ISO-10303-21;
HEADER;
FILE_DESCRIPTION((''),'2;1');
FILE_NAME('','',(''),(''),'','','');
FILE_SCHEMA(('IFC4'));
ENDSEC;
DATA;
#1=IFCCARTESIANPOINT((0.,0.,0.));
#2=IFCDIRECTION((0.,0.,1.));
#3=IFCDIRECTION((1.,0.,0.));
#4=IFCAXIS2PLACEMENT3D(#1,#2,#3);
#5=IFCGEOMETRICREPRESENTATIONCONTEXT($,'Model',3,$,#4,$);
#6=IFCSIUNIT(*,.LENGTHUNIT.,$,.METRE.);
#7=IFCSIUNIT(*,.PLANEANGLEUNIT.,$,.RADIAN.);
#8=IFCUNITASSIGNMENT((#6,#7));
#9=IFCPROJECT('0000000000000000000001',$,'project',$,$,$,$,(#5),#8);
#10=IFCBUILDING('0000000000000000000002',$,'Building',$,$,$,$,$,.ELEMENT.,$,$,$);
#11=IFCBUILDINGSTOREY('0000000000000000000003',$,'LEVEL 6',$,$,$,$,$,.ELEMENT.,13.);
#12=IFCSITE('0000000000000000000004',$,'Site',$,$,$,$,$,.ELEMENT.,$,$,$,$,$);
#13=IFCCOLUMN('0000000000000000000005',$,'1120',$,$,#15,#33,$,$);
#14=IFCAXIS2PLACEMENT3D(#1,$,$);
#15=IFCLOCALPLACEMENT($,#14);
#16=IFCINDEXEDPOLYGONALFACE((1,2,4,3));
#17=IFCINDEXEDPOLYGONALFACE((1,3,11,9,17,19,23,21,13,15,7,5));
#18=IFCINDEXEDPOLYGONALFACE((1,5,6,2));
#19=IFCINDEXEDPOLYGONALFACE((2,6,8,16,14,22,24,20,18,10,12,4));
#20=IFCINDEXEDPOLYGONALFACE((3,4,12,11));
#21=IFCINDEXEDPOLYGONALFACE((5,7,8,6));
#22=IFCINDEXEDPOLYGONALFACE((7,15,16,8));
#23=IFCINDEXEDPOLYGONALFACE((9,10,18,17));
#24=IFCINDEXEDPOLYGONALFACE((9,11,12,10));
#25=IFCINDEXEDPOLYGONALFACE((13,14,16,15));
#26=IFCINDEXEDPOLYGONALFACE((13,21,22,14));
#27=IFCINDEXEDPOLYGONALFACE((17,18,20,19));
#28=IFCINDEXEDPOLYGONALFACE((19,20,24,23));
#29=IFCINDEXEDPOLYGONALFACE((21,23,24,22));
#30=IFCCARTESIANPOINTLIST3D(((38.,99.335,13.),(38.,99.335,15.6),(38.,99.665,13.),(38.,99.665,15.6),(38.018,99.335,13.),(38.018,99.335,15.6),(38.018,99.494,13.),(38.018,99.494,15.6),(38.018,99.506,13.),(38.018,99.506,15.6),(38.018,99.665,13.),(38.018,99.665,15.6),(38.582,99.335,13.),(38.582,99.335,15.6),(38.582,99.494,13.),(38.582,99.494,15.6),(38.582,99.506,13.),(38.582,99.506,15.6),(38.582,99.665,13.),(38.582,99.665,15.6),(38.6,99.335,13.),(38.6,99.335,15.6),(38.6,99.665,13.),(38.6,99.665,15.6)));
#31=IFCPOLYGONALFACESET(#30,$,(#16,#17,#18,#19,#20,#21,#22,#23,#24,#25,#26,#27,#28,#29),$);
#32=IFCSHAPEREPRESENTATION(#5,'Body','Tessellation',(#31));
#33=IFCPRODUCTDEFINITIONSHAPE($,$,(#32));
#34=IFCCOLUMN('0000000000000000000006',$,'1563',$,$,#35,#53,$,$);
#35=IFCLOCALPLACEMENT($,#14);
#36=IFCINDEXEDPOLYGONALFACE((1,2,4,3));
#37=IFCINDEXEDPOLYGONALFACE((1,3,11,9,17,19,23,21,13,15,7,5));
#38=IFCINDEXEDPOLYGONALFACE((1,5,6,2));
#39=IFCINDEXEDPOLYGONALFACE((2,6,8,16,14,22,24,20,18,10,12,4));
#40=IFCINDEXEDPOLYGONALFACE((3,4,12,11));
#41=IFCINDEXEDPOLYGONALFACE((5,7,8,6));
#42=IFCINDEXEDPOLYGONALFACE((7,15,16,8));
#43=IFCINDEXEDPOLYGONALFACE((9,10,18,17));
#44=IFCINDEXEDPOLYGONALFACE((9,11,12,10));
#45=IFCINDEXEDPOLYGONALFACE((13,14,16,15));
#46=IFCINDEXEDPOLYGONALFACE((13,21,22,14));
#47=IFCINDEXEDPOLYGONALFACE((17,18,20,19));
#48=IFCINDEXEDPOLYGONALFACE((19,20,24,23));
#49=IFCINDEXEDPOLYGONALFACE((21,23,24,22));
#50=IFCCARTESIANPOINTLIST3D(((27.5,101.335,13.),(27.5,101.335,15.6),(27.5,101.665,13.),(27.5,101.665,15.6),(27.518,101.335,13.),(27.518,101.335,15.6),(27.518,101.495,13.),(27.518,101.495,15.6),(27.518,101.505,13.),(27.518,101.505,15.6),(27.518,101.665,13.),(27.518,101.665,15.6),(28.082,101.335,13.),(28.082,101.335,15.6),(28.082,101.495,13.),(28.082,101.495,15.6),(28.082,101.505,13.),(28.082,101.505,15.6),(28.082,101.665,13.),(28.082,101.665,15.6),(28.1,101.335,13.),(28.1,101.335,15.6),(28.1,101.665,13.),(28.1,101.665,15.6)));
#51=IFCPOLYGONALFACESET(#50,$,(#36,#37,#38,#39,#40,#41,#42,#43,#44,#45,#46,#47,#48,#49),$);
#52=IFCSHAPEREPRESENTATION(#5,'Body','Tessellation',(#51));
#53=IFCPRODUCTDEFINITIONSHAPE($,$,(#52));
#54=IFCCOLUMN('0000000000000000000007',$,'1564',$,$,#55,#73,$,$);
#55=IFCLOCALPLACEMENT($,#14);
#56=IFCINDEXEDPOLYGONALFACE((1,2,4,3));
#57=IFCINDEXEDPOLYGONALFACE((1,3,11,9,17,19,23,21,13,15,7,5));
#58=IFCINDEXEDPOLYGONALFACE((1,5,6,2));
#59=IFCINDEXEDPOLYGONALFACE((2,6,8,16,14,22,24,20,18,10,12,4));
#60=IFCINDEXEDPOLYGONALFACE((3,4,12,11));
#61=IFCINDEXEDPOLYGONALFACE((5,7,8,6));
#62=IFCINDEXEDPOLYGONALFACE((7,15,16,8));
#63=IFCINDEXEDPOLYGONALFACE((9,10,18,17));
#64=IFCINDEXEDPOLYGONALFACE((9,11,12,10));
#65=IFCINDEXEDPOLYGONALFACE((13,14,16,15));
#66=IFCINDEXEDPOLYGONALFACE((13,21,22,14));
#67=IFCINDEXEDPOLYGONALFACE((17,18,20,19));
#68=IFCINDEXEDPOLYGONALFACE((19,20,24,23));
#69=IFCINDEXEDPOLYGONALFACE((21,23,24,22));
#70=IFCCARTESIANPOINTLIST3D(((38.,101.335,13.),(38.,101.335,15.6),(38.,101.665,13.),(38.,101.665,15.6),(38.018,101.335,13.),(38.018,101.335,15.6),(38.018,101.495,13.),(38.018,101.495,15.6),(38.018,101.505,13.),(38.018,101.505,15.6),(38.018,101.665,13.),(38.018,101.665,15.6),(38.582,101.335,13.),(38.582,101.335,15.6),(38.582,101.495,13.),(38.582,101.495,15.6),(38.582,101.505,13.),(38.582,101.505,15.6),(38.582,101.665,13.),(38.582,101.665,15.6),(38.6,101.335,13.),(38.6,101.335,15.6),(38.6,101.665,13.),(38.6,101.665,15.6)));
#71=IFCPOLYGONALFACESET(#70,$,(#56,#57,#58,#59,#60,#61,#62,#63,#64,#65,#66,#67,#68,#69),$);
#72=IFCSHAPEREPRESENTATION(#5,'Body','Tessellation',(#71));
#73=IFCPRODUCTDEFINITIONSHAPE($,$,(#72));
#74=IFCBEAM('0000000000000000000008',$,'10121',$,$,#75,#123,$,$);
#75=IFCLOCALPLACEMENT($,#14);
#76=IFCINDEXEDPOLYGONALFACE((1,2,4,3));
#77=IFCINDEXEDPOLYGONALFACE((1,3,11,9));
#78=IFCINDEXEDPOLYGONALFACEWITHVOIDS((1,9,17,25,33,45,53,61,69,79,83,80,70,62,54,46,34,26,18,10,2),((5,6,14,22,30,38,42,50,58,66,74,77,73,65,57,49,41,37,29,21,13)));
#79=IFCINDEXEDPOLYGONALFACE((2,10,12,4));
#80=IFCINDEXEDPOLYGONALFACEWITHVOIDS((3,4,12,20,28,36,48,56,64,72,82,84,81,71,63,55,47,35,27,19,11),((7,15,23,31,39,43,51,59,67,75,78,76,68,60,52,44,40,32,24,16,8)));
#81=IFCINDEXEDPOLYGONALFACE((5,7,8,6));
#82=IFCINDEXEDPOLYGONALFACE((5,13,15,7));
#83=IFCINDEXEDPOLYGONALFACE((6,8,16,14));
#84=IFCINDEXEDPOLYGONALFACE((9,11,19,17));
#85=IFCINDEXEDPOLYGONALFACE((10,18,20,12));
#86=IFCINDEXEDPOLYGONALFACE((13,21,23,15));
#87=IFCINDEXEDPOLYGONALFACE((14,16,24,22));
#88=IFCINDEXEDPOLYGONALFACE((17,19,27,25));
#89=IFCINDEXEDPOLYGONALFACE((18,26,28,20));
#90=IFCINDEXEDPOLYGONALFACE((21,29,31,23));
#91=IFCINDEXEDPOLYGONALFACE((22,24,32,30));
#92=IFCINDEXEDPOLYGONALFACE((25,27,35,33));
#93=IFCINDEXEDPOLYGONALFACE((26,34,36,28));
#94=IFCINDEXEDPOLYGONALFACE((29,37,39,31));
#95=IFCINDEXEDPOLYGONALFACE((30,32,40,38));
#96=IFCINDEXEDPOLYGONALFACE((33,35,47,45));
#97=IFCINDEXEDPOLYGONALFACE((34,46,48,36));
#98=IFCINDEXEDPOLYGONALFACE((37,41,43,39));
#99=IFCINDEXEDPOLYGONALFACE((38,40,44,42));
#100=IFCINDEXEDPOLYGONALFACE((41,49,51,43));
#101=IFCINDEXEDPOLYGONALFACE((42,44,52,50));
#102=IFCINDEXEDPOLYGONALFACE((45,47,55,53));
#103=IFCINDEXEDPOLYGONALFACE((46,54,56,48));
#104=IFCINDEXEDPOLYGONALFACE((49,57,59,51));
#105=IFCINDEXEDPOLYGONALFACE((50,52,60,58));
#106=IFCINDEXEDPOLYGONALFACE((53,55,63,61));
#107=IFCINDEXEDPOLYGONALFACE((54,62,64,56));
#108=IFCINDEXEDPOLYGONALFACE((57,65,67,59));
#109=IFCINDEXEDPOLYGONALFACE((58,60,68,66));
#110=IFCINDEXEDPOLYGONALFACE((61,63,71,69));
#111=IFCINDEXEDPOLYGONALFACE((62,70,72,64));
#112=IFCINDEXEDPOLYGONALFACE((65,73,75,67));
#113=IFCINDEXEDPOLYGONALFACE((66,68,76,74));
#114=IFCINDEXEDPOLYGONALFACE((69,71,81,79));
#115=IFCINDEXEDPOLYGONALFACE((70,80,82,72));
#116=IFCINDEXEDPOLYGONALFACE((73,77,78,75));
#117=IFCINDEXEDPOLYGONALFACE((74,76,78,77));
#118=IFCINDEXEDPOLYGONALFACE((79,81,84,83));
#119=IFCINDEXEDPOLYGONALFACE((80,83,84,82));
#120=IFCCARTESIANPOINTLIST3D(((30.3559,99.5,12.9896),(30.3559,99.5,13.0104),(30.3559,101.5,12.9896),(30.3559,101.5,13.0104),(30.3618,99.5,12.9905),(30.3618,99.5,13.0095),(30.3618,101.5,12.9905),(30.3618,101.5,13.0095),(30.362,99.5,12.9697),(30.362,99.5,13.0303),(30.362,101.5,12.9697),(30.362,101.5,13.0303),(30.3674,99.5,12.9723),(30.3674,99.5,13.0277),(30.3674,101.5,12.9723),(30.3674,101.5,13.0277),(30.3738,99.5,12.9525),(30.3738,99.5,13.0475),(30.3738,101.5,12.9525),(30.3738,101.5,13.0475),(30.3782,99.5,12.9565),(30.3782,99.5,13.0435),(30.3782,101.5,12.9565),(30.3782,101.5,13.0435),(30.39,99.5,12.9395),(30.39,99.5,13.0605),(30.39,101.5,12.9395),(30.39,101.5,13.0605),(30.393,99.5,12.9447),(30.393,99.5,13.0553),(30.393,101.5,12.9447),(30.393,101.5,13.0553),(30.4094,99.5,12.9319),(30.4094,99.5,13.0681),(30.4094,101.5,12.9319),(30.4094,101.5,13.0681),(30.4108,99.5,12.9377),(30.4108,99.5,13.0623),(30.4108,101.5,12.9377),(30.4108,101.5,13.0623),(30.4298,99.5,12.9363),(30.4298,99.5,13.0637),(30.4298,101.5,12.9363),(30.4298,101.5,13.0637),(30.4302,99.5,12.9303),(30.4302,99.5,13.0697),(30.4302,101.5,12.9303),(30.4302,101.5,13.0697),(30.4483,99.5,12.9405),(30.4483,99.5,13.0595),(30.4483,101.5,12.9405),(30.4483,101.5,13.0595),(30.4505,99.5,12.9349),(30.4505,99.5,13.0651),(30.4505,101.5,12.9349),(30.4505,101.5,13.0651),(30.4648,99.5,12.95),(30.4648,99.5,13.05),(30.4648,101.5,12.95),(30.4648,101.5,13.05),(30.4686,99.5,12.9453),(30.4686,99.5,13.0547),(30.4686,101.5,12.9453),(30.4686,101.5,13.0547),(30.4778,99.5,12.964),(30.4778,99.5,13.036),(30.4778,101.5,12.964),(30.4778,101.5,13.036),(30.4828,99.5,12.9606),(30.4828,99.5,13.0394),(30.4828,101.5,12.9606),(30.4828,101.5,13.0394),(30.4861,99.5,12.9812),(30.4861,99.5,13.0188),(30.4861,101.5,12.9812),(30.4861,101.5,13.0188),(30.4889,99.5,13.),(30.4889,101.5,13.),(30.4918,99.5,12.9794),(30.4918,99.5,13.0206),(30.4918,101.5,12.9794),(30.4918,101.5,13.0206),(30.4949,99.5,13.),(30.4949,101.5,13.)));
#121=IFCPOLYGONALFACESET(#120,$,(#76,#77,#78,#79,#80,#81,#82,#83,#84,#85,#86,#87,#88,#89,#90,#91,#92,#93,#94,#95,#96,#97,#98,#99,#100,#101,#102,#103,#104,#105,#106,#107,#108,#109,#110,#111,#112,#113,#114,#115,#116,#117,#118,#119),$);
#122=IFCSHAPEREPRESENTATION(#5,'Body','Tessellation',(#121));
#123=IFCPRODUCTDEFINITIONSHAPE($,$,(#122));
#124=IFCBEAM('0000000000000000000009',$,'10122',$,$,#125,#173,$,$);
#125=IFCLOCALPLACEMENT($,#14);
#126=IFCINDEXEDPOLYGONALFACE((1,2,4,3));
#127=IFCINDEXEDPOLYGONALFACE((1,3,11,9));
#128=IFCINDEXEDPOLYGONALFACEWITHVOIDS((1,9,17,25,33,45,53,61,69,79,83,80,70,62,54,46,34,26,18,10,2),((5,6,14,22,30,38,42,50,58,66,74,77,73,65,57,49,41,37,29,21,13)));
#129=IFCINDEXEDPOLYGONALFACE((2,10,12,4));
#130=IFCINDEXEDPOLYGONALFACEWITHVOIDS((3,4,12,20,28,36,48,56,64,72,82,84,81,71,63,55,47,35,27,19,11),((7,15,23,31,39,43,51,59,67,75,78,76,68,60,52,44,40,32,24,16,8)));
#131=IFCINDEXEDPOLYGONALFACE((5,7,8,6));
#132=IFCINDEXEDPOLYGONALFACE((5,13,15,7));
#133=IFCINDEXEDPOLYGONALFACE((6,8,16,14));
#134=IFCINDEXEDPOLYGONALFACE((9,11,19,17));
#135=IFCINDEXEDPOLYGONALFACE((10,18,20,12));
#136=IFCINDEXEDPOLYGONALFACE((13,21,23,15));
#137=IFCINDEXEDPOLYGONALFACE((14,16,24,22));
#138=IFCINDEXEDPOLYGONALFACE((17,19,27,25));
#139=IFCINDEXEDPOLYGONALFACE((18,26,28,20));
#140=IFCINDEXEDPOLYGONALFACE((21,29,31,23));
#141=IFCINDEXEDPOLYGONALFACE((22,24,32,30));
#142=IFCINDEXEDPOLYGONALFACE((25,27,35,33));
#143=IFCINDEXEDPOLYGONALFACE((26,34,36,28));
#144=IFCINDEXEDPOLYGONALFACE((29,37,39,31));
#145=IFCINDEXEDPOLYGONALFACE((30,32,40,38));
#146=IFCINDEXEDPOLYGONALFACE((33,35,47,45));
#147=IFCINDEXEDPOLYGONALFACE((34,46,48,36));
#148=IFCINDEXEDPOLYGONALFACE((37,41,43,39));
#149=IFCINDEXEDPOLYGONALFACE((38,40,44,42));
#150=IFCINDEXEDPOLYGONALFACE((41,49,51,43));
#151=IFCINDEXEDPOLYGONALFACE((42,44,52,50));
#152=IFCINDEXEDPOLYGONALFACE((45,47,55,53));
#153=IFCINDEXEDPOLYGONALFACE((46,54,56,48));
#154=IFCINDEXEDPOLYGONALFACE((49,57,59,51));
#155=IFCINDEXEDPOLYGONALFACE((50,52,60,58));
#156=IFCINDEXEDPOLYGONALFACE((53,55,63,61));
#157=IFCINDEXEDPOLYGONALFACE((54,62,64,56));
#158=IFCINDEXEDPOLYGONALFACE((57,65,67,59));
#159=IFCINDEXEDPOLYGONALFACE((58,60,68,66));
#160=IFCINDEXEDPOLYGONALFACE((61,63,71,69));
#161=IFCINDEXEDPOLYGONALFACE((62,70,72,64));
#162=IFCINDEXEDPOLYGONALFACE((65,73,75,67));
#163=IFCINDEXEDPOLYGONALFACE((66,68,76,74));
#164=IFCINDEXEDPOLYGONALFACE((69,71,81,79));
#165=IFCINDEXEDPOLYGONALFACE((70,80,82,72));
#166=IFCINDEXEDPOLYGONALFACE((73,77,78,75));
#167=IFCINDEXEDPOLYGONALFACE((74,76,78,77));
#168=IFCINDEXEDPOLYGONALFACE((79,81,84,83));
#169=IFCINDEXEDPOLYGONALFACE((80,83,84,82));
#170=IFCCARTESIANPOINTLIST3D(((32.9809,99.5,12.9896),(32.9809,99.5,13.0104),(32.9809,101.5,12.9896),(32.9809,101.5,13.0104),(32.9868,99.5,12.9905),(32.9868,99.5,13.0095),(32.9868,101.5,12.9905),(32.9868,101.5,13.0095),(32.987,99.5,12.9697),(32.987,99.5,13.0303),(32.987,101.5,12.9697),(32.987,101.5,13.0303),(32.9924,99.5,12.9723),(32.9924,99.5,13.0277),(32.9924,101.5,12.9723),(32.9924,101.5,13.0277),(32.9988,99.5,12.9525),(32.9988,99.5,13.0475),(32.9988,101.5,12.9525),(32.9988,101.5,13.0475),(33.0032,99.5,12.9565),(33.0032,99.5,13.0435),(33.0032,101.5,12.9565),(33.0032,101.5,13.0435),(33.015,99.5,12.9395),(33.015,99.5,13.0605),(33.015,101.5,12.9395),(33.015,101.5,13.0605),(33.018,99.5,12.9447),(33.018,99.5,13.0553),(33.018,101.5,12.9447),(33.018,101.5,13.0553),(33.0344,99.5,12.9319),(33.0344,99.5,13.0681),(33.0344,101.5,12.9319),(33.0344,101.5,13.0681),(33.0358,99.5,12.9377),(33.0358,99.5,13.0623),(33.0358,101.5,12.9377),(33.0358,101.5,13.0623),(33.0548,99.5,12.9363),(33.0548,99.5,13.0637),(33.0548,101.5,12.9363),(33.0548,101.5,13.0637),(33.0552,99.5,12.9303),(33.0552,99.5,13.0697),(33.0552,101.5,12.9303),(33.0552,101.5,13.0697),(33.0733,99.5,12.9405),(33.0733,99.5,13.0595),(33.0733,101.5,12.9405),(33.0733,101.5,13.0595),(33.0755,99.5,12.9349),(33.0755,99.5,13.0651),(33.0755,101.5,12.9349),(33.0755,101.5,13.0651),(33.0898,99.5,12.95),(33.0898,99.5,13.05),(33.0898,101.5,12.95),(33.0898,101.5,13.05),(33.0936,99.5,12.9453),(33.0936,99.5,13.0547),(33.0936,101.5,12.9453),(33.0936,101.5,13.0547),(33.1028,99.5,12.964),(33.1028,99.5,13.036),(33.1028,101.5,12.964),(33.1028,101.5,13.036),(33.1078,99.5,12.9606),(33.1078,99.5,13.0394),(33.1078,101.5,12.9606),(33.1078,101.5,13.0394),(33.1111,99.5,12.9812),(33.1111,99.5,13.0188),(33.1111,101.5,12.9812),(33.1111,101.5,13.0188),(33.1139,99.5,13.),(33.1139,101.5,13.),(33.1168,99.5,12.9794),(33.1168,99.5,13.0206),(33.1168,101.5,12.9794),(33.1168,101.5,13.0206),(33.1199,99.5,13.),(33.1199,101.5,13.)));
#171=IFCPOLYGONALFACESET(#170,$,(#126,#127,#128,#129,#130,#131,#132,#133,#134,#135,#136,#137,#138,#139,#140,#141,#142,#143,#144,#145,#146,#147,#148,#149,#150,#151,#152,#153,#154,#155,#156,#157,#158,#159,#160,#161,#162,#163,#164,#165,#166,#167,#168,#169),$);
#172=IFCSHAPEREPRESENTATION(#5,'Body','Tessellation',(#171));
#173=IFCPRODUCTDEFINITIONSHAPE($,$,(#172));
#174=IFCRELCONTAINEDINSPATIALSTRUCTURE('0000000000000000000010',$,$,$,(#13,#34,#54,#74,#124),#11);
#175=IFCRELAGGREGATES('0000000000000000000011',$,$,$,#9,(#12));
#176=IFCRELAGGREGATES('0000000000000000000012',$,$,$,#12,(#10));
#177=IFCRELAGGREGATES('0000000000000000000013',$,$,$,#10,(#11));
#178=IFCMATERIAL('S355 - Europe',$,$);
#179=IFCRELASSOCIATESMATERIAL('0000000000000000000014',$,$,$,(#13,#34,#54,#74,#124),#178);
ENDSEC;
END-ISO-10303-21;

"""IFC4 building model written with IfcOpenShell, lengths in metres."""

from ifc_helpers import new_model, si_unit, frame, origin_with_axes, origin_2d_with_axis, place, context, project, spatial, hollow_circle, i_section, extrude, material, material_profile, profile_set, profile_usage, element, save


model = new_model("IFC4")

# Units and contexts
model_context = context("Model", 3, world=origin_with_axes())
ifc_project = project(units=[si_unit("LENGTHUNIT", "METRE"), si_unit("PLANEANGLEUNIT", "RADIAN")], contexts=[model_context])

# Site, building, storey
site = spatial("IfcSite", under=ifc_project, Name="Site", CompositionType="ELEMENT")
building = spatial("IfcBuilding", under=site, Name="Building", CompositionType="ELEMENT")
storey = spatial("IfcBuildingStorey", under=building, Name="LEVEL 6", CompositionType="ELEMENT", Elevation=13.0)

# Columns
ifc_material = material(Name="S355 - Europe")
ifc_material_profile_1 = material_profile(ifc_material, i_section(OverallWidth=0.33, OverallDepth=0.6, WebThickness=0.012, FlangeThickness=0.018, at=origin_2d_with_axis()))
ifc_profile_set_1 = profile_set([ifc_material_profile_1])
ifc_profile_usage_1 = profile_usage(ifc_profile_set_1, cardinal=10)
column_1_placement = place(None, frame((38.3, 99.5, 13.0), z_axis=(0.0, 0.0, 1.0), x_axis=(0.0, -1.0, 0.0)))
element("IfcColumn", 1, at=column_1_placement, inside=storey, material=ifc_profile_usage_1, Name="1120", context=model_context, shape_type="SweptSolid", body=[
    extrude(i_section(OverallWidth=0.33, OverallDepth=0.6, WebThickness=0.012, FlangeThickness=0.018, at=origin_2d_with_axis()), origin_with_axes(), (0.0, 0.0, 1.0), 2.6),
])
ifc_material_profile_2 = material_profile(ifc_material, i_section(OverallWidth=0.33, OverallDepth=0.6, WebThickness=0.01, FlangeThickness=0.018, at=origin_2d_with_axis()))
ifc_profile_set_2 = profile_set([ifc_material_profile_2])
ifc_profile_usage_2 = profile_usage(ifc_profile_set_2, cardinal=10)
column_2_placement = place(None, frame((27.8, 101.5, 13.0), z_axis=(0.0, 0.0, 1.0), x_axis=(0.0, -1.0, 0.0)))
element("IfcColumn", 2, at=column_2_placement, inside=storey, material=ifc_profile_usage_2, Name="1563", context=model_context, shape_type="SweptSolid", body=[
    extrude(i_section(OverallWidth=0.33, OverallDepth=0.6, WebThickness=0.01, FlangeThickness=0.018, at=origin_2d_with_axis()), origin_with_axes(), (0.0, 0.0, 1.0), 2.6),
])
ifc_material_profile_3 = material_profile(ifc_material, i_section(OverallWidth=0.33, OverallDepth=0.6, WebThickness=0.01, FlangeThickness=0.018, at=origin_2d_with_axis()))
ifc_profile_set_3 = profile_set([ifc_material_profile_3])
ifc_profile_usage_3 = profile_usage(ifc_profile_set_3, cardinal=10)
column_3_placement = place(None, frame((38.3, 101.5, 13.0), z_axis=(0.0, 0.0, 1.0), x_axis=(0.0, -1.0, 0.0)))
element("IfcColumn", 3, at=column_3_placement, inside=storey, material=ifc_profile_usage_3, Name="1564", context=model_context, shape_type="SweptSolid", body=[
    extrude(i_section(OverallWidth=0.33, OverallDepth=0.6, WebThickness=0.01, FlangeThickness=0.018, at=origin_2d_with_axis()), origin_with_axes(), (0.0, 0.0, 1.0), 2.6),
])

# Beams
ifc_material_profile_4 = material_profile(ifc_material, hollow_circle(Radius=0.0699, WallThickness=0.006, at=origin_2d_with_axis()))
ifc_profile_set_4 = profile_set([ifc_material_profile_4])
ifc_profile_usage_4 = profile_usage(ifc_profile_set_4, cardinal=10)
beam_1_placement = place(None, frame((30.425, 101.5, 13.0), z_axis=(0.0, -1.0, 0.0), x_axis=(1.0, 0.0, 0.0)))
element("IfcBeam", 4, at=beam_1_placement, inside=storey, material=ifc_profile_usage_4, Name="10121", context=model_context, shape_type="SweptSolid", body=[
    extrude(hollow_circle(Radius=0.0699, WallThickness=0.006, at=origin_2d_with_axis()), origin_with_axes(), (0.0, 0.0, 1.0), 2.0),
])
ifc_material_profile_5 = material_profile(ifc_material, hollow_circle(Radius=0.0699, WallThickness=0.006, at=origin_2d_with_axis()))
ifc_profile_set_5 = profile_set([ifc_material_profile_5])
ifc_profile_usage_5 = profile_usage(ifc_profile_set_5, cardinal=10)
beam_2_placement = place(None, frame((33.05, 101.5, 13.0), z_axis=(0.0, -1.0, 0.0), x_axis=(1.0, 0.0, 0.0)))
element("IfcBeam", 5, at=beam_2_placement, inside=storey, material=ifc_profile_usage_5, Name="10122", context=model_context, shape_type="SweptSolid", body=[
    extrude(hollow_circle(Radius=0.0699, WallThickness=0.006, at=origin_2d_with_axis()), origin_with_axes(), (0.0, 0.0, 1.0), 2.0),
])

save(model, "model.ifc")
